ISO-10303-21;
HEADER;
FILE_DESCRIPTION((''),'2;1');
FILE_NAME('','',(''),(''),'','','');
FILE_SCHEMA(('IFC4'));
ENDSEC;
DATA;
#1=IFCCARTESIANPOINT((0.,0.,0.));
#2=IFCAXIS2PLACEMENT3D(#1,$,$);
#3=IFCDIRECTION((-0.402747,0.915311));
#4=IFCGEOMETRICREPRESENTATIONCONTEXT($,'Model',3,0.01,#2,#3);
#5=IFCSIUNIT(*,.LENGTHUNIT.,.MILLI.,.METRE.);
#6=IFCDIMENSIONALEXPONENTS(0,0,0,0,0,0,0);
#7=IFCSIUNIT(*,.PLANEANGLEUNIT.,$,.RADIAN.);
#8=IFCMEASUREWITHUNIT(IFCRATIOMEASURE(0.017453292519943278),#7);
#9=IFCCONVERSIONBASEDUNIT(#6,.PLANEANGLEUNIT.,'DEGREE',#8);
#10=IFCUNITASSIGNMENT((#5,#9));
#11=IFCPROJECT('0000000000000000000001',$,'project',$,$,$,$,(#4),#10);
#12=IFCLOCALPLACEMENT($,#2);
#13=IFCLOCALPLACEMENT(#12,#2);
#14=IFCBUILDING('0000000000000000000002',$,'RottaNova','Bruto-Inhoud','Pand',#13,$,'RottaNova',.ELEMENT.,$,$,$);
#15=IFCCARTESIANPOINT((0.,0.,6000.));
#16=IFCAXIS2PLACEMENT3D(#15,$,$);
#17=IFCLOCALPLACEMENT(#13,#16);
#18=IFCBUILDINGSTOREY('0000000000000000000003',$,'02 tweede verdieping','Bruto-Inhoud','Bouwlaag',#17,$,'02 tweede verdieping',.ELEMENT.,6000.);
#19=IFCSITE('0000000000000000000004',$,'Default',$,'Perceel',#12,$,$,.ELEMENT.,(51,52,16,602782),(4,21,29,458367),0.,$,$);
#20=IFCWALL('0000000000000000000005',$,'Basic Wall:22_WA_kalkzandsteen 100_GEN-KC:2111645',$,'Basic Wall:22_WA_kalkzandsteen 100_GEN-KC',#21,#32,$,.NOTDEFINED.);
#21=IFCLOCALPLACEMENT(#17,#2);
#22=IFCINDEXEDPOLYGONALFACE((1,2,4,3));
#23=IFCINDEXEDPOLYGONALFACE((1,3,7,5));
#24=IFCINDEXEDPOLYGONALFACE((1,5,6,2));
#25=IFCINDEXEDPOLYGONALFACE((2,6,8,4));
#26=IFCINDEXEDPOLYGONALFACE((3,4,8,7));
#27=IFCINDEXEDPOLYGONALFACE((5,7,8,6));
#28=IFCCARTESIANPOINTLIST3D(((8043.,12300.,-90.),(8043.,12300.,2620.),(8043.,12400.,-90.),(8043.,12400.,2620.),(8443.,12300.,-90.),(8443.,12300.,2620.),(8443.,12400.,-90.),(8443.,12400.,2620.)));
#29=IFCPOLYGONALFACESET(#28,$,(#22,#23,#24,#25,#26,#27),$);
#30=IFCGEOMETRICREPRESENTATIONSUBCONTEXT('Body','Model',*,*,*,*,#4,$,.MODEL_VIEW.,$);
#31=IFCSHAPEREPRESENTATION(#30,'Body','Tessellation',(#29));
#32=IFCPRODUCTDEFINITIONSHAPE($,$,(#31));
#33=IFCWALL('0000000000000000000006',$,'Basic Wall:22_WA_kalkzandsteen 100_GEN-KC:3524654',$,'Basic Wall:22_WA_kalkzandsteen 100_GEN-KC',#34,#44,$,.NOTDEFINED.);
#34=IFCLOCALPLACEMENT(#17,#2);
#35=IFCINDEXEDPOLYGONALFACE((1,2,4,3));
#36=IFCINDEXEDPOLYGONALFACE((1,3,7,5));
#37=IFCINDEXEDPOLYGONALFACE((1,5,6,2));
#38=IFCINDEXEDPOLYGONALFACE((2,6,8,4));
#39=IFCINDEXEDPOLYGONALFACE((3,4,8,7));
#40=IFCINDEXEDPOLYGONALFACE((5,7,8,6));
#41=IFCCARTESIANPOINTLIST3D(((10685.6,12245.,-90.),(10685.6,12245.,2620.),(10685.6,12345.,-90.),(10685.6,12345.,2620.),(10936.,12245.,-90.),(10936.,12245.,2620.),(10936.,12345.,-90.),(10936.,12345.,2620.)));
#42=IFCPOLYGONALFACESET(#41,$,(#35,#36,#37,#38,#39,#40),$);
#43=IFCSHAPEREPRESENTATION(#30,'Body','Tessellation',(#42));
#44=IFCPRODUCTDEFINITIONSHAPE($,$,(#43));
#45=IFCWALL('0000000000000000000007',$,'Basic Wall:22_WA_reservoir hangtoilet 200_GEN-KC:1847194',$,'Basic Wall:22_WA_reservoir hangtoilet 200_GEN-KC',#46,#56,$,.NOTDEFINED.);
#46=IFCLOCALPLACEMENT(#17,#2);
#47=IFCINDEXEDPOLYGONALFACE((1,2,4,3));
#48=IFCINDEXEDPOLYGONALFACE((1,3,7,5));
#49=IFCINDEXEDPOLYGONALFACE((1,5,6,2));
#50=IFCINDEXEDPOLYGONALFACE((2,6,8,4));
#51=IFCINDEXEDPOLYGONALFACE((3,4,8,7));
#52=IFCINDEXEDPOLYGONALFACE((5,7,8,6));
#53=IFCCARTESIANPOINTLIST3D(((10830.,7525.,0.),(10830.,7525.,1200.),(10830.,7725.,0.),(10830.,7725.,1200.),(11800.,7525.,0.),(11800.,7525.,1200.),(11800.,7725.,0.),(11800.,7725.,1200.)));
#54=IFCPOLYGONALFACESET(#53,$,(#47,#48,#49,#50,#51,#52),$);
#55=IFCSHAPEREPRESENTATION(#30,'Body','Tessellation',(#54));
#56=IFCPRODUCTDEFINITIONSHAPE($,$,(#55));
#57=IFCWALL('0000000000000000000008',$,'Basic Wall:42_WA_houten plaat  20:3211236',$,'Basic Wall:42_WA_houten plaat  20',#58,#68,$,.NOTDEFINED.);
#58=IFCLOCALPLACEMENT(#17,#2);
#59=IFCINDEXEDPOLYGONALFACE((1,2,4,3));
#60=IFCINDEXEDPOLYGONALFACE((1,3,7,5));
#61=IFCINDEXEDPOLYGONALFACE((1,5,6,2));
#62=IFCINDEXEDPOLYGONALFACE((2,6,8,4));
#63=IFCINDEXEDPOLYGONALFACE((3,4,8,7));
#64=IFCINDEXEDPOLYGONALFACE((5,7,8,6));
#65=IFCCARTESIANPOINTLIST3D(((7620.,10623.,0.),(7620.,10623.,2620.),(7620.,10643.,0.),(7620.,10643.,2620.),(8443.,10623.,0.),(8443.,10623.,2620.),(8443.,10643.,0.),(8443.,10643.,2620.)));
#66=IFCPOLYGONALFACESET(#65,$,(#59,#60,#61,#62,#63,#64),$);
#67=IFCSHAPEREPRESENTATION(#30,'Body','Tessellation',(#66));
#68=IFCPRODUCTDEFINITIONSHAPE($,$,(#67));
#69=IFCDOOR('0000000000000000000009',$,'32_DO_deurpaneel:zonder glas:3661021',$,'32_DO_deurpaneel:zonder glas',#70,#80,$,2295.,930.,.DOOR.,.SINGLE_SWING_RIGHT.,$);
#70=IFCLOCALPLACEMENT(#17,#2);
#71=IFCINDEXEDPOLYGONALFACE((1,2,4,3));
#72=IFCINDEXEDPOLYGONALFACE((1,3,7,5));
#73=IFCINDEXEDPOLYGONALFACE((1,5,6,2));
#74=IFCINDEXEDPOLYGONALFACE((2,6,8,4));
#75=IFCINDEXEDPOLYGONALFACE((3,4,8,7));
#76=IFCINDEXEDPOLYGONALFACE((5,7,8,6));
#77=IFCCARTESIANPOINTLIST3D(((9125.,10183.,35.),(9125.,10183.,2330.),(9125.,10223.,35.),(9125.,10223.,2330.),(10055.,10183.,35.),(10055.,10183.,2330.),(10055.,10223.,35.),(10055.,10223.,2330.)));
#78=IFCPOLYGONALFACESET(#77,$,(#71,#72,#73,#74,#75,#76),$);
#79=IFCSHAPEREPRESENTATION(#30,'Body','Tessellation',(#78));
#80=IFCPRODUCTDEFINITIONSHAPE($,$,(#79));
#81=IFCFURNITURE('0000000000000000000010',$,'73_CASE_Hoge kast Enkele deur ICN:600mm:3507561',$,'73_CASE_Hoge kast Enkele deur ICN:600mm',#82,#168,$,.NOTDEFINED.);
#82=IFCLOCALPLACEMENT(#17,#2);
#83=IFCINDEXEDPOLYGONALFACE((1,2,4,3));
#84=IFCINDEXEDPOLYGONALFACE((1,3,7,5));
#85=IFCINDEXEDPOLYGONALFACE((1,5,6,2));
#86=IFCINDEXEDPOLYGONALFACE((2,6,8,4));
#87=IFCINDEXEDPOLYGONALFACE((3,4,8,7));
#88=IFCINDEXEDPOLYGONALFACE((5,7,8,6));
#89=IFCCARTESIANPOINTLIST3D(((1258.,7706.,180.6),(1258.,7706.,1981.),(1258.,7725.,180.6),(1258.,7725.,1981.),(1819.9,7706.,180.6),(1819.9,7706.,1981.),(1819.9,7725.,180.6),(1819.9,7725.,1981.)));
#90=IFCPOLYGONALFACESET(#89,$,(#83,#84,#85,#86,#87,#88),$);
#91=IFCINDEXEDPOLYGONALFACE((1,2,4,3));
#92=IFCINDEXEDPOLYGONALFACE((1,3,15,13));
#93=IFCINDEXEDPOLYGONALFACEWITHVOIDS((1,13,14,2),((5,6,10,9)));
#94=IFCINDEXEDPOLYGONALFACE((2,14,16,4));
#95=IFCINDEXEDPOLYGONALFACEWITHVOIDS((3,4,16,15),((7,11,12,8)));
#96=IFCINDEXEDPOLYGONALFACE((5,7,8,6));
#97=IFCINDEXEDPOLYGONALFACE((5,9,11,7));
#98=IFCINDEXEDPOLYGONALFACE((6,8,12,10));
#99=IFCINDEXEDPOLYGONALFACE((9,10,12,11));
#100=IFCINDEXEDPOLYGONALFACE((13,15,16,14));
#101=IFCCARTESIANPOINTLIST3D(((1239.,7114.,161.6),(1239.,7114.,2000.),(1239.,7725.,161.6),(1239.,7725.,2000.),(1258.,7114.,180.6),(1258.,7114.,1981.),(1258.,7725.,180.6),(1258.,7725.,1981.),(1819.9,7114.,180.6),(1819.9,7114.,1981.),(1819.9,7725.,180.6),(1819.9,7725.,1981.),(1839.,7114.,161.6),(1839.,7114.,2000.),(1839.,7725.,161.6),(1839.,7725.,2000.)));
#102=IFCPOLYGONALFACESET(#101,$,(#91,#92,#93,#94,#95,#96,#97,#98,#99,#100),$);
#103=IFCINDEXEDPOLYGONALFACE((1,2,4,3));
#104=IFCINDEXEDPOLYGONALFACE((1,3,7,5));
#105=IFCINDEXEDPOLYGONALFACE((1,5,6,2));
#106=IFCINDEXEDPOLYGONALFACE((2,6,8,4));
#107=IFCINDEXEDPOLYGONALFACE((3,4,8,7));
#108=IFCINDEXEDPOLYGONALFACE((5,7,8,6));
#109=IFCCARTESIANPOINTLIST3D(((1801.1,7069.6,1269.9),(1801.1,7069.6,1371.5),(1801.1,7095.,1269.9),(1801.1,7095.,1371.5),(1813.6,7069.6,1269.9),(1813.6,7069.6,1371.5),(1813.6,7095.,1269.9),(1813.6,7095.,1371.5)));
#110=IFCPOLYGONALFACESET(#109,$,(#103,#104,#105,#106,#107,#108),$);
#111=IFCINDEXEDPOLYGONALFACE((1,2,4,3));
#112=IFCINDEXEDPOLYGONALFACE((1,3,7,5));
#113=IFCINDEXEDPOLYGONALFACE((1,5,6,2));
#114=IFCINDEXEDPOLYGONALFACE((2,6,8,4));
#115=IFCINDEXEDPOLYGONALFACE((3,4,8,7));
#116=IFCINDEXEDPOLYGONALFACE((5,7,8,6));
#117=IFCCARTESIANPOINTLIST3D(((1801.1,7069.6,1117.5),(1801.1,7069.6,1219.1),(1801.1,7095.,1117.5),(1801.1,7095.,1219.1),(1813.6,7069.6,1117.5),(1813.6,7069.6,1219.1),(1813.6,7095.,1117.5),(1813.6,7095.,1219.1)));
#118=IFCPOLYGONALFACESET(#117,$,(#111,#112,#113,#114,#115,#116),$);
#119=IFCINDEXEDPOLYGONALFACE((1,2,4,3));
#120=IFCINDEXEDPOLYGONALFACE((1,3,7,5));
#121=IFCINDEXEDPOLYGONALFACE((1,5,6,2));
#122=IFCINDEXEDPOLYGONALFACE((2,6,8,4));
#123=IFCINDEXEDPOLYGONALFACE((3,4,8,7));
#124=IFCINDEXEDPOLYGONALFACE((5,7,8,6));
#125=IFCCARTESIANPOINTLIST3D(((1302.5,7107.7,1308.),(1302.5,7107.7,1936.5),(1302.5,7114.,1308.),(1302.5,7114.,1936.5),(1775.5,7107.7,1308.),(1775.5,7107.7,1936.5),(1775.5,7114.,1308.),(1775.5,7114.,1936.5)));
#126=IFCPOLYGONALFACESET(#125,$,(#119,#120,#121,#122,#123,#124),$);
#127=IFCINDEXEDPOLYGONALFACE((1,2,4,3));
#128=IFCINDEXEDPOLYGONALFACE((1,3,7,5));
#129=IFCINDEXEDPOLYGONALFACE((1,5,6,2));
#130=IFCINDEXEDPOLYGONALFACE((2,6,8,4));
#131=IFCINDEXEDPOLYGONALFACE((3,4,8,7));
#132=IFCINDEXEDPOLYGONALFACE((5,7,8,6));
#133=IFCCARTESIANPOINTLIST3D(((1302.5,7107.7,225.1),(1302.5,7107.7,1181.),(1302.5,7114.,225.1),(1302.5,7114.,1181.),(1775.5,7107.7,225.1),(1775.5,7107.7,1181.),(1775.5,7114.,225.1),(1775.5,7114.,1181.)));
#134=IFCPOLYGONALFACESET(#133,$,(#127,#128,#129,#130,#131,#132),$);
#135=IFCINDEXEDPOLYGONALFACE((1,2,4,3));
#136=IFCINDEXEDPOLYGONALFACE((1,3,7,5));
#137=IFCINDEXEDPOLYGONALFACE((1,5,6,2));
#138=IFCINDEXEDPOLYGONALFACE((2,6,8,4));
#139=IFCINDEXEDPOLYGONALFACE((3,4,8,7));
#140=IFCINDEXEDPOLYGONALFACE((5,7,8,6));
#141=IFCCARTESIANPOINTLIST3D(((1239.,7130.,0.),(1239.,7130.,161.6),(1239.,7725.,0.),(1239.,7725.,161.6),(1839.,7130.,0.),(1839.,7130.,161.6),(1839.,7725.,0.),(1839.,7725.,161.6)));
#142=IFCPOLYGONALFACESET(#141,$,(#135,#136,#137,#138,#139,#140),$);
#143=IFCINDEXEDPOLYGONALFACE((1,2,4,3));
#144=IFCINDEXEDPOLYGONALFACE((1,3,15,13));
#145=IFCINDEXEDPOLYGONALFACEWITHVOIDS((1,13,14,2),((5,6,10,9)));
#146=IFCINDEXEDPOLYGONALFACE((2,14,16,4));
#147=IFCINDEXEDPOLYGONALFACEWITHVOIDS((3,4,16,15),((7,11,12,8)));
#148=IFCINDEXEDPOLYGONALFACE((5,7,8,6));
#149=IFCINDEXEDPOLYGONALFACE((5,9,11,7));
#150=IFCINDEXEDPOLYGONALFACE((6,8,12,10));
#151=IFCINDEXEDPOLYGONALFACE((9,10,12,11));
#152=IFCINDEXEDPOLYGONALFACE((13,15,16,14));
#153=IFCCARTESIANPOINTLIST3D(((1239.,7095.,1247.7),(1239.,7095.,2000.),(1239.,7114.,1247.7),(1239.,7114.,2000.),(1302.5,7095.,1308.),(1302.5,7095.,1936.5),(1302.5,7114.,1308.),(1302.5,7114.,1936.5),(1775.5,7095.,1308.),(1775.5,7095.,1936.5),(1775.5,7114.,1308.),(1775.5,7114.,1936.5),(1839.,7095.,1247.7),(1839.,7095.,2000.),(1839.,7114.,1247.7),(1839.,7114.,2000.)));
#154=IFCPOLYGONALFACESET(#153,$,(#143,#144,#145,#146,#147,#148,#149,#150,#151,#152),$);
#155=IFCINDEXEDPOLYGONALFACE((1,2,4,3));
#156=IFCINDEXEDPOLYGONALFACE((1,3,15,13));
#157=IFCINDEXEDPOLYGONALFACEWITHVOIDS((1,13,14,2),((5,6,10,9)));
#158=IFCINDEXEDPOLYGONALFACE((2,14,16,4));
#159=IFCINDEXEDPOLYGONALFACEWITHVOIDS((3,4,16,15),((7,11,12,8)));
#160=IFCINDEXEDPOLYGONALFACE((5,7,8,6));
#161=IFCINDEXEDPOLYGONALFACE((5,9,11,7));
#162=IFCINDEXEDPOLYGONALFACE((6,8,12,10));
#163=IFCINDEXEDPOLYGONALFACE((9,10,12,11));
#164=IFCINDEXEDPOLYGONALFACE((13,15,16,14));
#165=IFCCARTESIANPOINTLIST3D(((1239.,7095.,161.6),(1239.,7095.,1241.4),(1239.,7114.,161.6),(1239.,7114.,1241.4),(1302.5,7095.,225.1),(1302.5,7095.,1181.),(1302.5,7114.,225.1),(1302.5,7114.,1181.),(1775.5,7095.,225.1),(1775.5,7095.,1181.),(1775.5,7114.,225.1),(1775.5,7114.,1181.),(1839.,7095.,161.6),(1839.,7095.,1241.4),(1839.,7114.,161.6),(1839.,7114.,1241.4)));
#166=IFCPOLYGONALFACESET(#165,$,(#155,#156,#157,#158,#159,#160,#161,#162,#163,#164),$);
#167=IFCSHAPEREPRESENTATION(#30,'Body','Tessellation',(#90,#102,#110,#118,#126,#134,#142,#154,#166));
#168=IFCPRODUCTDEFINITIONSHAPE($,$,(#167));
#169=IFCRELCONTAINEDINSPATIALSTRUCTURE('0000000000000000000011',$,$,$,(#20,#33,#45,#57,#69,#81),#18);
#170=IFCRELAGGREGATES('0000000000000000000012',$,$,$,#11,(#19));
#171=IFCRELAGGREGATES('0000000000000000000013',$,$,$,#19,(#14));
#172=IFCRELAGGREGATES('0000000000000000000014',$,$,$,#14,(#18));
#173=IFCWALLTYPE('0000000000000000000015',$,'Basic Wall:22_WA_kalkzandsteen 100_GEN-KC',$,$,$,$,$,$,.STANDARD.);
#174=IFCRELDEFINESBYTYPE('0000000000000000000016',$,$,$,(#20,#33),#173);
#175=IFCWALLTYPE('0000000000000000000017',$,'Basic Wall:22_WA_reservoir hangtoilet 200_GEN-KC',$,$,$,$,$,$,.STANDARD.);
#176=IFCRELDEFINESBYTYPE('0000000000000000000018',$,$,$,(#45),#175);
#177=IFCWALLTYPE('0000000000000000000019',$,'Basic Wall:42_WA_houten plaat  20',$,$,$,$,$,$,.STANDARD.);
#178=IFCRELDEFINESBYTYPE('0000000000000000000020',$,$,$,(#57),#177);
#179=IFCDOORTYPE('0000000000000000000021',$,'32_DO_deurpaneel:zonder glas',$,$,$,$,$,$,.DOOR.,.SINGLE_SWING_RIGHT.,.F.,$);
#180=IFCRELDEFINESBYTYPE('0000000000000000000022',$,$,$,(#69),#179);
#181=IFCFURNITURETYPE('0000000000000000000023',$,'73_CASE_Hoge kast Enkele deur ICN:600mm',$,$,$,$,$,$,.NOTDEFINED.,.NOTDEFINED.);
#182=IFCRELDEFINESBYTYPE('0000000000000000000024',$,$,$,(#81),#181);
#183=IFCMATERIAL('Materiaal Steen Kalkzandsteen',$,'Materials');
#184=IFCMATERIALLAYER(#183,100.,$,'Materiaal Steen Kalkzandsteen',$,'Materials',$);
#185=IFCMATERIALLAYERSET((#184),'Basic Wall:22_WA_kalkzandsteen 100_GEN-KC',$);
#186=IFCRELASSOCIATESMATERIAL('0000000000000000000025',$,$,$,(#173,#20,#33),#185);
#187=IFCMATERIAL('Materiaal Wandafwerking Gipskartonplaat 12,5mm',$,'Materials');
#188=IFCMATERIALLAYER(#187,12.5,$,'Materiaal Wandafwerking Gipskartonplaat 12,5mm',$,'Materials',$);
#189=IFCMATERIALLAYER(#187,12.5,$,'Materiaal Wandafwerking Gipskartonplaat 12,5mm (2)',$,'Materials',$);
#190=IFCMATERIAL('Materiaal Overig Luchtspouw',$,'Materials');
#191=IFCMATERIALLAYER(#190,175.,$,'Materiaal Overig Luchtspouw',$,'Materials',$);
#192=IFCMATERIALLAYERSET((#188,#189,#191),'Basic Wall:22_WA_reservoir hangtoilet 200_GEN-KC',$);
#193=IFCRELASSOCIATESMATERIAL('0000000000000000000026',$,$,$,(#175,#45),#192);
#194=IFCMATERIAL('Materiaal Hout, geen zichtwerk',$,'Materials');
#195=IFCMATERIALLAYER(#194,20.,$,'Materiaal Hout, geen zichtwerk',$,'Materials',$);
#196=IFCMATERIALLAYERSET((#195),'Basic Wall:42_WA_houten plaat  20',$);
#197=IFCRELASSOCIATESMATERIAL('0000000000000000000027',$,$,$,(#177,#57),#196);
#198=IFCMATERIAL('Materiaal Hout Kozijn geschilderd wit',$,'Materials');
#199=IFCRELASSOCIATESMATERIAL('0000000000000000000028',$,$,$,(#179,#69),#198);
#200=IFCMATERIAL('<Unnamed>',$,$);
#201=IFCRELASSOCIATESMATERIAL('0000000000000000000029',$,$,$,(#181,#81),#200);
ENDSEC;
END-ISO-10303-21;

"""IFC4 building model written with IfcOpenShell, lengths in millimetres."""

from ifc_helpers import new_model, entity, si_unit, converted_unit, direction, frame, frame_2d, origin, origin_2d_with_axis, place, context, subcontext, project, spatial, polyline, rectangle, outline, extrude, source, transform, mapped, material, layer, layer_set, type_object, type_shapes, element, save


model = new_model("IFC4")

# Units and contexts
model_context = context("Model", 3, precision=0.01, world=origin(), true_north=direction((-0.402747, 0.915311)))
body_context = subcontext(model_context, "Body", "Model", "MODEL_VIEW")
ifc_project = project(units=[si_unit("LENGTHUNIT", "METRE", prefix="MILLI"), converted_unit("PLANEANGLEUNIT", "DEGREE", entity("IfcRatioMeasure", 0.017453292519943278), si_unit("PLANEANGLEUNIT", "RADIAN"), dimensions=[0, 0, 0, 0, 0, 0, 0])], contexts=[model_context])

# Site, building, storey
site_placement = place(None, origin())
site = spatial("IfcSite", under=ifc_project, at=site_placement, Name="Default", ObjectType="Perceel", CompositionType="ELEMENT", RefLatitude=(51, 52, 16, 602782), RefLongitude=(4, 21, 29, 458367), RefElevation=0.0)
building_placement = place(site_placement, origin())
building = spatial("IfcBuilding", under=site, at=building_placement, Name="RottaNova", Description="Bruto-Inhoud", ObjectType="Pand", LongName="RottaNova", CompositionType="ELEMENT")
storey_placement = place(building_placement, frame((0.0, 0.0, 6000.0)))
storey = spatial("IfcBuildingStorey", under=building, at=storey_placement, Name="02 tweede verdieping", Description="Bruto-Inhoud", ObjectType="Bouwlaag", LongName="02 tweede verdieping", CompositionType="ELEMENT", Elevation=6000.0)

# Shared definitions
ifc_material_1 = material(Name="Materiaal Steen Kalkzandsteen", Category="Materials")

# Walls
ifc_layer_1 = layer(ifc_material_1, 100.0, Name="Materiaal Steen Kalkzandsteen", Category="Materials")
ifc_layer_set_1 = layer_set([ifc_layer_1], Name="Basic Wall:22_WA_kalkzandsteen 100_GEN-KC")
wall_type_1 = type_object("IfcWallType", Name="Basic Wall:22_WA_kalkzandsteen 100_GEN-KC", PredefinedType="STANDARD", material=ifc_layer_set_1)
wall_1_placement = place(storey_placement, frame((8043.0, 12350.0, -90.0)))
element("IfcWall", 1, at=wall_1_placement, inside=storey, type_object=wall_type_1, material=ifc_layer_set_1, Name="Basic Wall:22_WA_kalkzandsteen 100_GEN-KC:2111645", ObjectType="Basic Wall:22_WA_kalkzandsteen 100_GEN-KC", PredefinedType="NOTDEFINED", context=body_context, shape_type="SweptSolid", body=[
    extrude(rectangle(XDim=400.0, YDim=100.0, at=frame_2d((200.0, 0.0), x_axis=(-1.0, 0.0))), origin(), (0.0, 0.0, 1.0), 2710.0),
])
wall_2_placement = place(storey_placement, frame((10685.6, 12295.0, -90.0)))
element("IfcWall", 2, at=wall_2_placement, inside=storey, type_object=wall_type_1, material=ifc_layer_set_1, Name="Basic Wall:22_WA_kalkzandsteen 100_GEN-KC:3524654", ObjectType="Basic Wall:22_WA_kalkzandsteen 100_GEN-KC", PredefinedType="NOTDEFINED", context=body_context, shape_type="SweptSolid", body=[
    extrude(rectangle(XDim=250.4, YDim=100.0, at=frame_2d((125.2, 0.0), x_axis=(-1.0, 0.0))), origin(), (0.0, 0.0, 1.0), 2710.0),
])
ifc_material_2 = material(Name="Materiaal Wandafwerking Gipskartonplaat 12,5mm", Category="Materials")
ifc_layer_2 = layer(ifc_material_2, 12.5, Name="Materiaal Wandafwerking Gipskartonplaat 12,5mm", Category="Materials")
ifc_layer_3 = layer(ifc_material_2, 12.5, Name="Materiaal Wandafwerking Gipskartonplaat 12,5mm (2)", Category="Materials")
ifc_material_3 = material(Name="Materiaal Overig Luchtspouw", Category="Materials")
ifc_layer_4 = layer(ifc_material_3, 175.0, Name="Materiaal Overig Luchtspouw", Category="Materials")
ifc_layer_set_2 = layer_set([ifc_layer_2, ifc_layer_3, ifc_layer_4], Name="Basic Wall:22_WA_reservoir hangtoilet 200_GEN-KC")
wall_type_2 = type_object("IfcWallType", Name="Basic Wall:22_WA_reservoir hangtoilet 200_GEN-KC", PredefinedType="STANDARD", material=ifc_layer_set_2)
wall_3_placement = place(storey_placement, frame((10830.0, 7625.0, 0.0)))
element("IfcWall", 3, at=wall_3_placement, inside=storey, type_object=wall_type_2, material=ifc_layer_set_2, Name="Basic Wall:22_WA_reservoir hangtoilet 200_GEN-KC:1847194", ObjectType="Basic Wall:22_WA_reservoir hangtoilet 200_GEN-KC", PredefinedType="NOTDEFINED", context=body_context, shape_type="SweptSolid", body=[
    extrude(rectangle(XDim=970.0, YDim=200.0, at=frame_2d((485.0, 0.0), x_axis=(-1.0, 0.0))), origin(), (0.0, 0.0, 1.0), 1200.0),
])
ifc_material_4 = material(Name="Materiaal Hout, geen zichtwerk", Category="Materials")
ifc_layer_5 = layer(ifc_material_4, 20.0, Name="Materiaal Hout, geen zichtwerk", Category="Materials")
ifc_layer_set_3 = layer_set([ifc_layer_5], Name="Basic Wall:42_WA_houten plaat  20")
wall_type_3 = type_object("IfcWallType", Name="Basic Wall:42_WA_houten plaat  20", PredefinedType="STANDARD", material=ifc_layer_set_3)
wall_4_placement = place(storey_placement, frame((7620.0, 10633.0, 0.0)))
element("IfcWall", 4, at=wall_4_placement, inside=storey, type_object=wall_type_3, material=ifc_layer_set_3, Name="Basic Wall:42_WA_houten plaat  20:3211236", ObjectType="Basic Wall:42_WA_houten plaat  20", PredefinedType="NOTDEFINED", context=body_context, shape_type="SweptSolid", body=[
    extrude(rectangle(XDim=823.0, YDim=20.0, at=frame_2d((411.5, 0.0), x_axis=(-1.0, 0.0))), origin(), (0.0, 0.0, 1.0), 2620.0),
])

# Door
ifc_material_5 = material(Name="Materiaal Hout Kozijn geschilderd wit", Category="Materials")
door_type = type_object("IfcDoorType", Name="32_DO_deurpaneel:zonder glas", OperationType="SINGLE_SWING_RIGHT", ParameterTakesPrecedence=False, PredefinedType="DOOR", material=ifc_material_5)
shared_shape_1 = source(origin(), body_context, "Body", "SweptSolid", [
    extrude(rectangle(XDim=2295.0, YDim=40.0, at=frame_2d((0.0, 0.0), x_axis=(0.0, 1.0))), frame((-465.0, -20.0, 1182.5), z_axis=(1.0, 0.0, 0.0), x_axis=(0.0, 1.0, 0.0)), (0.0, 0.0, 1.0), 930.0),
])
type_shapes(door_type, [shared_shape_1])
door_placement = place(storey_placement, frame((9590.0, 10223.0, 0.0)))
element("IfcDoor", 5, at=door_placement, inside=storey, type_object=door_type, material=ifc_material_5, Name="32_DO_deurpaneel:zonder glas:3661021", ObjectType="32_DO_deurpaneel:zonder glas", OperationType="SINGLE_SWING_RIGHT", OverallHeight=2295.0, OverallWidth=930.0, PredefinedType="DOOR", context=body_context, shape_type="MappedRepresentation", body=[
    mapped(shared_shape_1, transform((0.0, 0.0, 0.0), scale=1.0)),
])

# Furniture
ifc_material_6 = material(Name="<Unnamed>")
furniture_type = type_object("IfcFurnitureType", Name="73_CASE_Hoge kast Enkele deur ICN:600mm", AssemblyPlace="NOTDEFINED", PredefinedType="NOTDEFINED", material=ifc_material_6)
shared_shape_2 = source(origin(), body_context, "Body", "SweptSolid", [
    extrude(rectangle(XDim=19.1, YDim=561.9, at=origin_2d_with_axis()), frame((18.7, -9.5, 180.6), z_axis=(0.0, 0.0, 1.0), x_axis=(0.0, 1.0, 0.0)), (0.0, 0.0, 1.0), 1800.3),
    extrude(outline(polyline([(-300.0, -919.2), (300.0, -919.2), (300.0, 919.2), (-300.0, 919.2), (-300.0, -919.2)]), holes=[polyline([(-280.9, 900.2), (281.0, 900.2), (281.0, -900.2), (-280.9, -900.2), (-280.9, 900.2)])]), frame((18.7, -610.9, 1080.8), z_axis=(0.0, 1.0, 0.0), x_axis=(-1.0, 0.0, 0.0)), (0.0, 0.0, 1.0), 610.9),
    extrude(rectangle(XDim=25.4, YDim=12.5, at=frame_2d((0.0, 0.0), x_axis=(1.0, 0.0))), frame((287.1, -642.7, 1269.9), z_axis=(0.0, 0.0, 1.0), x_axis=(0.0, 1.0, 0.0)), (0.0, 0.0, 1.0), 101.6),
    extrude(rectangle(XDim=25.4, YDim=12.5, at=frame_2d((0.0, 0.0), x_axis=(1.0, 0.0))), frame((287.1, -642.7, 1117.5), z_axis=(0.0, 0.0, 1.0), x_axis=(0.0, 1.0, 0.0)), (0.0, 0.0, 1.0), 101.6),
    extrude(rectangle(XDim=6.4, YDim=473.0, at=frame_2d((0.0, 0.0), x_axis=(1.0, 0.0))), frame((18.7, -614.1, 1308.0), z_axis=(0.0, 0.0, 1.0), x_axis=(0.0, 1.0, 0.0)), (0.0, 0.0, 1.0), 628.5),
    extrude(rectangle(XDim=6.4, YDim=473.0, at=origin_2d_with_axis()), frame((18.7, -614.1, 225.1), z_axis=(0.0, 0.0, 1.0), x_axis=(0.0, 1.0, 0.0)), (0.0, 0.0, 1.0), 956.0),
    extrude(rectangle(XDim=600.0, YDim=595.0, at=frame_2d((0.0, 0.0), x_axis=(1.0, 0.0))), frame((18.7, -297.5, 0.0), z_axis=(0.0, 0.0, 1.0), x_axis=(-1.0, 0.0, 0.0)), (0.0, 0.0, 1.0), 161.6),
    extrude(outline(polyline([(-376.1, -300.0), (376.1, -300.0), (376.1, 300.0), (-376.1, 300.0), (-376.1, -300.0)]), holes=[polyline([(-312.6, -236.5), (-312.6, 236.5), (315.8, 236.5), (315.8, -236.5), (-312.6, -236.5)])]), frame((18.7, -630.0, 1623.9), z_axis=(0.0, 1.0, 0.0), x_axis=(0.0, 0.0, -1.0)), (0.0, 0.0, 1.0), 19.1),
    extrude(outline(polyline([(-300.0, -539.9), (300.0, -539.9), (300.0, 539.9), (-300.0, 539.9), (-300.0, -539.9)]), holes=[polyline([(-236.5, 479.6), (236.5, 479.6), (236.5, -476.4), (-236.5, -476.4), (-236.5, 479.6)])]), frame((18.7, -630.0, 701.5), z_axis=(0.0, 1.0, 0.0), x_axis=(-1.0, 0.0, 0.0)), (0.0, 0.0, 1.0), 19.1),
])
type_shapes(furniture_type, [shared_shape_2])
for number, where, name in (
    (6, (1520.3, 7725.0, 0.0), "73_CASE_Hoge kast Enkele deur ICN:600mm:3507561"),
):
    element("IfcFurniture", number, at=place(storey_placement, frame(where)), inside=storey, type_object=furniture_type, material=ifc_material_6, Name=name, ObjectType="73_CASE_Hoge kast Enkele deur ICN:600mm", PredefinedType="NOTDEFINED", context=body_context, shape_type="MappedRepresentation", body=[
        mapped(shared_shape_2, transform((0.0, 0.0, 0.0), scale=1.0)),
    ])

save(model, "model.ifc")
